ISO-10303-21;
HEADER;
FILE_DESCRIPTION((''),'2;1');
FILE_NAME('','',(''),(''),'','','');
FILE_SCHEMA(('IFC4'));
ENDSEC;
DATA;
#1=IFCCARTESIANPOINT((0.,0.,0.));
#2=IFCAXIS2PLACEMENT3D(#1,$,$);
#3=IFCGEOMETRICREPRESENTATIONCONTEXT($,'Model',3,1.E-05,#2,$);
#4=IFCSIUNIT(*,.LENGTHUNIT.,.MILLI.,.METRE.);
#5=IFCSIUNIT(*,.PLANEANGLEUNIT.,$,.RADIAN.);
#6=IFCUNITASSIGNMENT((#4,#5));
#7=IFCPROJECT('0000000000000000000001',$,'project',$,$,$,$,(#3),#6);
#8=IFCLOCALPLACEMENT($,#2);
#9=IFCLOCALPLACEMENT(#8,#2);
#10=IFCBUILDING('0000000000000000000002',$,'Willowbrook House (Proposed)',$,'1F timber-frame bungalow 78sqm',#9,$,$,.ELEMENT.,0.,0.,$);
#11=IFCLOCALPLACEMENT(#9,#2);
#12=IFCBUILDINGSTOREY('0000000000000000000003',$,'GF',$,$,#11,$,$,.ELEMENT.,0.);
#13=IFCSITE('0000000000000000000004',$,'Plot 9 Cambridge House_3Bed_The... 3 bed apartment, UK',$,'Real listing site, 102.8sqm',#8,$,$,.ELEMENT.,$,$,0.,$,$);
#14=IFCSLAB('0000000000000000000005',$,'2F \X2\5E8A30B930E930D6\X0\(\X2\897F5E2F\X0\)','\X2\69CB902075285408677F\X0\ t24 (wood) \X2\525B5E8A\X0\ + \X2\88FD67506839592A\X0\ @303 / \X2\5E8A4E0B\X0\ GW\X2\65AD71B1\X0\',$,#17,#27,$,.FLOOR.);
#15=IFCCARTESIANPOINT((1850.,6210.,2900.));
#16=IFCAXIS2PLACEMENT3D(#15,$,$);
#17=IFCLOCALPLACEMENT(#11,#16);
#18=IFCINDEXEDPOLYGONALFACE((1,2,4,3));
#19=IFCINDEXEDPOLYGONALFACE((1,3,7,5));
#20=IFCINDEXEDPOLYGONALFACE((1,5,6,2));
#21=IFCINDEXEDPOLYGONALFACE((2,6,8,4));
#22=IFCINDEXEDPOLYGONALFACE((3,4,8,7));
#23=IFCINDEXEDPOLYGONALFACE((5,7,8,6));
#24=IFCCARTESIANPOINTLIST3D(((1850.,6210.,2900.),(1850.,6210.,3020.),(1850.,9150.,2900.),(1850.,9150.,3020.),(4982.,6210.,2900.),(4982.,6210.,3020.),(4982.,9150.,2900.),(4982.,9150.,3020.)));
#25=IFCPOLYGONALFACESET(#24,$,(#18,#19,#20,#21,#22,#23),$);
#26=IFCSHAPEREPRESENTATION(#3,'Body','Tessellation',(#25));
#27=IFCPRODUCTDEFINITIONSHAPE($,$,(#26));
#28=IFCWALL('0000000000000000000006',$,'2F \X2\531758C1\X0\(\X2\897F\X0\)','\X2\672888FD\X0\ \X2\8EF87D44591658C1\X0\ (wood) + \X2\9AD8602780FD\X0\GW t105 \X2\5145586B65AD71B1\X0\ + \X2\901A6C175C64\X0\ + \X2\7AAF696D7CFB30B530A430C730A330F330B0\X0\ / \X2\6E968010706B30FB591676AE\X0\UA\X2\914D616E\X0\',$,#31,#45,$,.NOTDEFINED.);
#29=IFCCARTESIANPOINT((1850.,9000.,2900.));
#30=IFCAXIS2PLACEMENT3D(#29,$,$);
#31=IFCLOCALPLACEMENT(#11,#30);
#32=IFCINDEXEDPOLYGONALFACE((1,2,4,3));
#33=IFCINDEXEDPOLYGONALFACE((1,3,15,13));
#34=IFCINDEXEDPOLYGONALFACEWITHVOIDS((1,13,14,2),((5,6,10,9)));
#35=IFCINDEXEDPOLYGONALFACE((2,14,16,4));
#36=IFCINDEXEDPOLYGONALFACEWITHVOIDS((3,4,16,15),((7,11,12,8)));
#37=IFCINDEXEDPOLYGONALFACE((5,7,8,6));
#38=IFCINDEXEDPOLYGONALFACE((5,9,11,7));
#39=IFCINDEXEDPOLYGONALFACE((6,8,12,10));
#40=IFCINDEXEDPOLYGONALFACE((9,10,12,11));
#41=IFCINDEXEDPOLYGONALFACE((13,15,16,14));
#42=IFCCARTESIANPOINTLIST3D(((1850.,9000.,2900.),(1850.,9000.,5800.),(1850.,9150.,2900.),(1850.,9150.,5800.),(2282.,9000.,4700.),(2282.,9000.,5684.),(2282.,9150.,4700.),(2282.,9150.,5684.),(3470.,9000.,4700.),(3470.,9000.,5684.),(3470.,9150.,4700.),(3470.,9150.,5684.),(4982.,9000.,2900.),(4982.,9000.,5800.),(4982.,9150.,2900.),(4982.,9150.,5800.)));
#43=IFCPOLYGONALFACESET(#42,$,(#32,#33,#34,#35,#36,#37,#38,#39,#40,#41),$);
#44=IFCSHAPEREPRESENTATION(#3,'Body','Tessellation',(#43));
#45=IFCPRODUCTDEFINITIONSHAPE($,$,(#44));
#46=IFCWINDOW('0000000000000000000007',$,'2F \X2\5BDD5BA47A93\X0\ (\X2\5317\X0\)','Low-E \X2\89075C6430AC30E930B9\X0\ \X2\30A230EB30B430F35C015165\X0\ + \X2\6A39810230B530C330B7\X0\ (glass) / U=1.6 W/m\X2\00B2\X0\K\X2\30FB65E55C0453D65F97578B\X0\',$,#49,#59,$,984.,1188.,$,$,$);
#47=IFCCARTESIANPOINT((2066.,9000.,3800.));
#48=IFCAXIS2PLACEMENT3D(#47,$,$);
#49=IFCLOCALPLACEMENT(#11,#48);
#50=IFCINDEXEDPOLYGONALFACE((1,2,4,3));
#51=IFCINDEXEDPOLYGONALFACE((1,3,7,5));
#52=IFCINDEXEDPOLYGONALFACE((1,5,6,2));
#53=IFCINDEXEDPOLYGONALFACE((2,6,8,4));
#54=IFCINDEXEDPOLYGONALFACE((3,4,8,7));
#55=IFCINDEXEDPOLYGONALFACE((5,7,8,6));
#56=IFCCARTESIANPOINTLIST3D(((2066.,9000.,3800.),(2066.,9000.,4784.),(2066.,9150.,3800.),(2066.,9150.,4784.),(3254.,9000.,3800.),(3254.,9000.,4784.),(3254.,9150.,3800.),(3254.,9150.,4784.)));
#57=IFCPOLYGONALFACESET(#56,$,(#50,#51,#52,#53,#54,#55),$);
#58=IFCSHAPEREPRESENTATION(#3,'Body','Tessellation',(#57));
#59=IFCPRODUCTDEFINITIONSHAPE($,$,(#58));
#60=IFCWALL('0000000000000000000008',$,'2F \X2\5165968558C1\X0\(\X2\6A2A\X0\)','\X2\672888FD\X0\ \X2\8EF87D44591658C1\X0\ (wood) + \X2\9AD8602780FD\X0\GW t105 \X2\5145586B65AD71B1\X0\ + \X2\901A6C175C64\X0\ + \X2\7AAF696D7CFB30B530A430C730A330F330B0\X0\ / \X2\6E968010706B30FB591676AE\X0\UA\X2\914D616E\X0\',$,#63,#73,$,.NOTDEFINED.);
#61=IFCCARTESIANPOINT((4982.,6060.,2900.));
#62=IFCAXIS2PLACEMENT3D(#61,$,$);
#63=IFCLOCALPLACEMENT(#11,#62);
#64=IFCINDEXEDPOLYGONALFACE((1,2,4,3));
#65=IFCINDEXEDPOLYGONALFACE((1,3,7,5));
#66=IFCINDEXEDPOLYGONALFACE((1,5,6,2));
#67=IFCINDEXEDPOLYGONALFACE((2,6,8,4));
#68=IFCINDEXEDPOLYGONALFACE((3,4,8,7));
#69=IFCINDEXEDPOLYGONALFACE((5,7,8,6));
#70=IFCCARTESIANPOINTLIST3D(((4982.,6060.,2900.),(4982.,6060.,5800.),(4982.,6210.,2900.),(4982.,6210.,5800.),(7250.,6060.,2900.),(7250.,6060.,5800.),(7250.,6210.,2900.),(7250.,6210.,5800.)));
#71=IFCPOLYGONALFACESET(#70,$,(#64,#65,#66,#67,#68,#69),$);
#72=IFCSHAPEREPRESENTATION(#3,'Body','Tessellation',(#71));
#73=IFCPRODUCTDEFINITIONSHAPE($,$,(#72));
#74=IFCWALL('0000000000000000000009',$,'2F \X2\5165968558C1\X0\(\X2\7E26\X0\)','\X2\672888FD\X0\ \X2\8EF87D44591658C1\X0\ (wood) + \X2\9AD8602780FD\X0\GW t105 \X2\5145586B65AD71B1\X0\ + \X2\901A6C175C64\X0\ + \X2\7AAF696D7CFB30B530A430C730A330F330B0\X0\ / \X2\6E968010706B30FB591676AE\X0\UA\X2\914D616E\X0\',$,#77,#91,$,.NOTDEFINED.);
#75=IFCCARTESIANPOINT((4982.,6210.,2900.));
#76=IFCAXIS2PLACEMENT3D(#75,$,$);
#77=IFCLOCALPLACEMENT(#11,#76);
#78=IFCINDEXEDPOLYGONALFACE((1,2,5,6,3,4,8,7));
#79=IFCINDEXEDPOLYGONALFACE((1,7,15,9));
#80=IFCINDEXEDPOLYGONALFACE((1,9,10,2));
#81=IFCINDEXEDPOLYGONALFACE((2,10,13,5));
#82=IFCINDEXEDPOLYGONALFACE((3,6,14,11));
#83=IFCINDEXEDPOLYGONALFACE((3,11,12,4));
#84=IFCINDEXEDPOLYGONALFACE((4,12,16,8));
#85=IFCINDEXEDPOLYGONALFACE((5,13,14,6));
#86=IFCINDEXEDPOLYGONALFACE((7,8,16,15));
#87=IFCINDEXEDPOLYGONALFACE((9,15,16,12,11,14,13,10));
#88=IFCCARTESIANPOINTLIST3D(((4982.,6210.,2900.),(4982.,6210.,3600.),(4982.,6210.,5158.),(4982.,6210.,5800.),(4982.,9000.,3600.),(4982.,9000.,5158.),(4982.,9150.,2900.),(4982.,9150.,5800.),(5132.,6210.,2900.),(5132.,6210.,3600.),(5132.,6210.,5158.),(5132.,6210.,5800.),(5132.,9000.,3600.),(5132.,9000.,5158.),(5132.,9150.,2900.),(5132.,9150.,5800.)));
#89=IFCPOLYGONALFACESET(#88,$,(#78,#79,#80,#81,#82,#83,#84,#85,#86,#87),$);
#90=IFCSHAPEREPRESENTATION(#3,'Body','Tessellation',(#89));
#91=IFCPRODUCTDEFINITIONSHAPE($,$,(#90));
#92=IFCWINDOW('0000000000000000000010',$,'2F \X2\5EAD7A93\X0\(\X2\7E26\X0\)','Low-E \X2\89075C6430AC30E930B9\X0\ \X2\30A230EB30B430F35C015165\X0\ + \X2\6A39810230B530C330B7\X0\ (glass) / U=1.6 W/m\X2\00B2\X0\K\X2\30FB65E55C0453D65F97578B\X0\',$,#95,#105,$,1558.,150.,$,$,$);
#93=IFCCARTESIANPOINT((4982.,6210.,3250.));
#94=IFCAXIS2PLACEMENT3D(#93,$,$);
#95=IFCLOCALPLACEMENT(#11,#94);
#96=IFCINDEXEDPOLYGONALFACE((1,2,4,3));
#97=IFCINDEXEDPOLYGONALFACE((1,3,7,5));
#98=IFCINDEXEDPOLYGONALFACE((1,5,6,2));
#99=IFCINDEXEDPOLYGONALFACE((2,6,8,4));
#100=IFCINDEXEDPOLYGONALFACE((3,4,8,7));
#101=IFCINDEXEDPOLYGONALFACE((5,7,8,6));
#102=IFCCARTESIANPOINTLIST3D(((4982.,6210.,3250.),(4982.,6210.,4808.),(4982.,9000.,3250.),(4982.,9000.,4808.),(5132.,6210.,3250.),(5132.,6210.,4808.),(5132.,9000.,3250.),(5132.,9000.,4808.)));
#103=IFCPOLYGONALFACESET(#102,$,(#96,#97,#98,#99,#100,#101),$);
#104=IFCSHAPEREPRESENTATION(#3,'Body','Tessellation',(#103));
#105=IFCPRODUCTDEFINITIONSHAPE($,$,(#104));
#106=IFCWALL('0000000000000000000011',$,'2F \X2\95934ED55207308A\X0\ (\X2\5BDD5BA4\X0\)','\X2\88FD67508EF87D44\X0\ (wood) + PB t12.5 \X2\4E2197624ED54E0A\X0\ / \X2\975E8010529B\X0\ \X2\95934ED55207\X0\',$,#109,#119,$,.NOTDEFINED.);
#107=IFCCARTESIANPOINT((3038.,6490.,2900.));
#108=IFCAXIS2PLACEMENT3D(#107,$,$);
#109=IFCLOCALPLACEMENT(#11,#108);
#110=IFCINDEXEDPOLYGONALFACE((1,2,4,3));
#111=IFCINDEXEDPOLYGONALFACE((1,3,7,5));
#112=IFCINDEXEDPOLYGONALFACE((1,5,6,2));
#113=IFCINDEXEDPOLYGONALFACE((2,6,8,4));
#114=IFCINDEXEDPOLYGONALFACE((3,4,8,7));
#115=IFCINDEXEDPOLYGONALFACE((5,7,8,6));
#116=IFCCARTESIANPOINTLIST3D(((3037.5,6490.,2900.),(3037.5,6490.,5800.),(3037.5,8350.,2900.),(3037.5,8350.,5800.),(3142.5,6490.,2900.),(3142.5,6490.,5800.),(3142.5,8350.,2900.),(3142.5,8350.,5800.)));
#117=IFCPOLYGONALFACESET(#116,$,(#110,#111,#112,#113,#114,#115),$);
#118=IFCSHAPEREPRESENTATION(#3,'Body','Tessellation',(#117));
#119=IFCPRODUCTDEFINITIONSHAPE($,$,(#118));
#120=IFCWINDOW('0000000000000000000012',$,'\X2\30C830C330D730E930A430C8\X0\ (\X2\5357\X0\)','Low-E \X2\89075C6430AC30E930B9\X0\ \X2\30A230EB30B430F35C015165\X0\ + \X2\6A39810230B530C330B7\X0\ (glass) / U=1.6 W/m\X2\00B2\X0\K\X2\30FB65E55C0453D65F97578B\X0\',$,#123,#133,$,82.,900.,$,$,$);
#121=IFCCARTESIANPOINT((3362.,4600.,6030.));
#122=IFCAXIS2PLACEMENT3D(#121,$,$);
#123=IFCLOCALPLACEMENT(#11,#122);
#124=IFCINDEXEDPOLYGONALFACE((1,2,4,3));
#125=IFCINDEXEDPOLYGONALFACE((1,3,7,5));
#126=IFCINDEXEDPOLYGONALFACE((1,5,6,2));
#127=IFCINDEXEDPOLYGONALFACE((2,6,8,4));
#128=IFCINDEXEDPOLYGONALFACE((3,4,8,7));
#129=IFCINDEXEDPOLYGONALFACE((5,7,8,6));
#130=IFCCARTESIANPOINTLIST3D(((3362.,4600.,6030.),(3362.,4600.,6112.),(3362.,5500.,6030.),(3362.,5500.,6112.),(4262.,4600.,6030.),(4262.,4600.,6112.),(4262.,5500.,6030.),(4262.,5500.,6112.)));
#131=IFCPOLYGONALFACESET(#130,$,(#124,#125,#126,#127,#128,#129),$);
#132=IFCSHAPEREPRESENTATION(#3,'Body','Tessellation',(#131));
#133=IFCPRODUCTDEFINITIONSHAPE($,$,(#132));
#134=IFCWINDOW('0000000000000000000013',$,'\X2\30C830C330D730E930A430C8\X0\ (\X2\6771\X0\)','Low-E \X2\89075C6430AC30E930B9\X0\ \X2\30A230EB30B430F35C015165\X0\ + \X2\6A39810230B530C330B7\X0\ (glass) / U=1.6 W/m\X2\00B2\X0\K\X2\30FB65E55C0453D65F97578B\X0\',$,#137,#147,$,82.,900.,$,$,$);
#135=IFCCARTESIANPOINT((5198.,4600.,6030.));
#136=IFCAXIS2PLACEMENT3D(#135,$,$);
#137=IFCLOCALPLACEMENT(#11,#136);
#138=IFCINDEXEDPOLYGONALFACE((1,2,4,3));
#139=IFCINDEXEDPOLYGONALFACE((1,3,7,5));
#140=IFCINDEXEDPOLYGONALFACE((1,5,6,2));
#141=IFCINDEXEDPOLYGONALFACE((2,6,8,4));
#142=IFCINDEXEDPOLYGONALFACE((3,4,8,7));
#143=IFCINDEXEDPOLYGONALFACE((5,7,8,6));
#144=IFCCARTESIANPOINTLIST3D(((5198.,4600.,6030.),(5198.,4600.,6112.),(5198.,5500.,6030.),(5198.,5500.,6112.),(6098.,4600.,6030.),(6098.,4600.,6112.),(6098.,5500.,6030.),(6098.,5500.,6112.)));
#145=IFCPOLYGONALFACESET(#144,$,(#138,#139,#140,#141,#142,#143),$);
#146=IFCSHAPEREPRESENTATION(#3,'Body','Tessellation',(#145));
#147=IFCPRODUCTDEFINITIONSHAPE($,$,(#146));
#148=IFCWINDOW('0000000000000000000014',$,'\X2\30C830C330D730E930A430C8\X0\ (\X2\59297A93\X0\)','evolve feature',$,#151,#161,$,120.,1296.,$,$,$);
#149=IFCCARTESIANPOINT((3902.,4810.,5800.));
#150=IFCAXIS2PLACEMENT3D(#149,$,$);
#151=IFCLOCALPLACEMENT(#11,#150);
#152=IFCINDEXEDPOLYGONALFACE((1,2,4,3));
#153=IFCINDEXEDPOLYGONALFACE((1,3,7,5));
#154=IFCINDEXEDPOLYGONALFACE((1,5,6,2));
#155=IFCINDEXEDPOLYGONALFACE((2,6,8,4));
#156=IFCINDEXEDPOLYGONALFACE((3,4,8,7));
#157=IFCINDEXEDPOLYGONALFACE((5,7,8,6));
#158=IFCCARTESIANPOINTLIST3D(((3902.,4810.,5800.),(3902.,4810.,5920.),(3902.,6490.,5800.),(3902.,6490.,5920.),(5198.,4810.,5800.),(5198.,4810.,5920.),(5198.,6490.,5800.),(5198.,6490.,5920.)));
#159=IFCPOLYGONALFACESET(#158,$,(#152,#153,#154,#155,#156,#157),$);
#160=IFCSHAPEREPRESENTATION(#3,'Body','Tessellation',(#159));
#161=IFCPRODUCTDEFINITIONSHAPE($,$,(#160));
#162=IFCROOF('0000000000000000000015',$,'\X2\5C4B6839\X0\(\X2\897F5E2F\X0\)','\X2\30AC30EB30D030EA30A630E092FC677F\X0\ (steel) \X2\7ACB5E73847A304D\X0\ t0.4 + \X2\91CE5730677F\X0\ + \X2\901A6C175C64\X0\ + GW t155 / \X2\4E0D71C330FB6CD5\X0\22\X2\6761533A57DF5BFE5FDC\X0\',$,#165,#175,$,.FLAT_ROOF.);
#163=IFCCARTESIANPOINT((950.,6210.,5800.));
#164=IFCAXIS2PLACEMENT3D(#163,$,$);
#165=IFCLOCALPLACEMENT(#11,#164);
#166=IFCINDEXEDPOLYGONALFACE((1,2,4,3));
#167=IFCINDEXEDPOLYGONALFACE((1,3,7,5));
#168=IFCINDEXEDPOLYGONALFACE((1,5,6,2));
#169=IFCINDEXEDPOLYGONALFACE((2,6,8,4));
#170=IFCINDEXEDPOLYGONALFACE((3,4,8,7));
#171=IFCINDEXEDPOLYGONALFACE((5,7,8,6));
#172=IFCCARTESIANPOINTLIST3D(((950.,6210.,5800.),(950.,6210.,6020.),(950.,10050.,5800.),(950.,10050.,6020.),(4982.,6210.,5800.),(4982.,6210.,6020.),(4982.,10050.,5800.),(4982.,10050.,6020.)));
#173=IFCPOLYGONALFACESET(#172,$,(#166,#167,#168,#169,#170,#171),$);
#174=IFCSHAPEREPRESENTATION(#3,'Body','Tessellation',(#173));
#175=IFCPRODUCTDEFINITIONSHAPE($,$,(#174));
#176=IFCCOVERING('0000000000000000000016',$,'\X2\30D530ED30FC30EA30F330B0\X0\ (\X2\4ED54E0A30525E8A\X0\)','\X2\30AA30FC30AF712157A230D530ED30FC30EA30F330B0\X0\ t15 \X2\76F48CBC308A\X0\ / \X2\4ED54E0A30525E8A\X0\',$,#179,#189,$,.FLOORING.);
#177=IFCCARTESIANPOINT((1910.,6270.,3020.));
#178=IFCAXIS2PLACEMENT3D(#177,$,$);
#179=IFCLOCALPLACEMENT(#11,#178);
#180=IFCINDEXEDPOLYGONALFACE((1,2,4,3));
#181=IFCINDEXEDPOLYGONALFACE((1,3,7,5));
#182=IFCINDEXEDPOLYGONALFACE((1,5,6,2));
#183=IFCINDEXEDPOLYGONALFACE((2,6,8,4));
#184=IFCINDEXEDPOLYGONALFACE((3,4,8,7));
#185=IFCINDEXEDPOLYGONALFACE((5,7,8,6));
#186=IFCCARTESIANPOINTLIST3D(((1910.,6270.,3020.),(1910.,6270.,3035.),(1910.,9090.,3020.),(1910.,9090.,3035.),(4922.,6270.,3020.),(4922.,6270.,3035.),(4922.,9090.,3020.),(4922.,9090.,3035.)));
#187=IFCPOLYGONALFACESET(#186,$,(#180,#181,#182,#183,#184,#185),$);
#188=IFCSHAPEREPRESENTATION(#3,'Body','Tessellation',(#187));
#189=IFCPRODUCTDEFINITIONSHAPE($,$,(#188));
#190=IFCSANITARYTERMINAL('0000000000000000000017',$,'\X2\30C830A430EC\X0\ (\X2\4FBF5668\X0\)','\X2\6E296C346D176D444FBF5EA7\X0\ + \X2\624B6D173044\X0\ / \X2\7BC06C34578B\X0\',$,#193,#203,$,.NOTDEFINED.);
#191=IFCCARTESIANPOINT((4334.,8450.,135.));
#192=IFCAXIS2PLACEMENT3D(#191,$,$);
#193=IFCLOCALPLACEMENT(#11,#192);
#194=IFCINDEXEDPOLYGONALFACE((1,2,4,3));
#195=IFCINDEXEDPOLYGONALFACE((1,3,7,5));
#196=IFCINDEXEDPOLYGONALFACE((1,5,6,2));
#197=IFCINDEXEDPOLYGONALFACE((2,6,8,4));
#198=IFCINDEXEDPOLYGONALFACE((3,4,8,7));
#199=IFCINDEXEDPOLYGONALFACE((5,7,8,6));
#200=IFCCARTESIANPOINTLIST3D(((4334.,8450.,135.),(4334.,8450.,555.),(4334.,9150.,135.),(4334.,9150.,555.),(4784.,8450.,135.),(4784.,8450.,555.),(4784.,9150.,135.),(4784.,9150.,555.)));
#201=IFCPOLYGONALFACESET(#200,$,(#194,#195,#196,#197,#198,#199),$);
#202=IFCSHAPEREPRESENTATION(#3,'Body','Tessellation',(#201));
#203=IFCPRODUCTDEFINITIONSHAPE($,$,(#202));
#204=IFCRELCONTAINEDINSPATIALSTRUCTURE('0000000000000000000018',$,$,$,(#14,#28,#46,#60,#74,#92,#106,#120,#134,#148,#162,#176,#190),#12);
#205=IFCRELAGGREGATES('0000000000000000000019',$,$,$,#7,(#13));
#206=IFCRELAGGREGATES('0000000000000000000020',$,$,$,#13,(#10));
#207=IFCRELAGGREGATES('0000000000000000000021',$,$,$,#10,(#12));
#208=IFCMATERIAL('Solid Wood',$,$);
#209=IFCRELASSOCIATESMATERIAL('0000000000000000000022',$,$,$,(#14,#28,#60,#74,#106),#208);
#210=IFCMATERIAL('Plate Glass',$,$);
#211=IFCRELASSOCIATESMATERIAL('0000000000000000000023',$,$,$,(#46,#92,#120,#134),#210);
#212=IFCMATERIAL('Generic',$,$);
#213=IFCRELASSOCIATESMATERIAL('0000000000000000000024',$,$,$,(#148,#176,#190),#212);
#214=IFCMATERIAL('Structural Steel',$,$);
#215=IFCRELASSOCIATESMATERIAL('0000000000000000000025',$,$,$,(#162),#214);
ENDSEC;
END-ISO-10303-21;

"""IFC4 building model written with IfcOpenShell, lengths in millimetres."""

from ifc_helpers import new_model, si_unit, frame, frame_2d, origin, place, context, project, spatial, rectangle, extrude, material, element, fill, save


model = new_model("IFC4")

# Units and contexts
model_context = context("Model", 3, precision=1e-05, world=origin())
ifc_project = project(units=[si_unit("LENGTHUNIT", "METRE", prefix="MILLI"), si_unit("PLANEANGLEUNIT", "RADIAN")], contexts=[model_context])

# Site, building, storey
site_placement = place(None, origin())
site = spatial("IfcSite", under=ifc_project, at=site_placement, Name="Plot 9 Cambridge House_3Bed_The... 3 bed apartment, UK", ObjectType="Real listing site, 102.8sqm", CompositionType="ELEMENT", RefElevation=0.0)
building_placement = place(site_placement, origin())
building = spatial("IfcBuilding", under=site, at=building_placement, Name="Willowbrook House (Proposed)", ObjectType="1F timber-frame bungalow 78sqm", CompositionType="ELEMENT", ElevationOfRefHeight=0.0, ElevationOfTerrain=0.0)
storey_placement = place(building_placement, origin())
storey = spatial("IfcBuildingStorey", under=building, at=storey_placement, Name="GF", CompositionType="ELEMENT", Elevation=0.0)

# Slab
ifc_material_1 = material(Name="Solid Wood")
slab_placement = place(storey_placement, frame((1850.0, 6210.0, 2900.0)))
element("IfcSlab", 1, at=slab_placement, inside=storey, material=ifc_material_1, Name="2F 床スラブ(西帯)", Description="構造用合板 t24 (wood) 剛床 + 製材根太 @303 / 床下 GW断熱", PredefinedType="FLOOR", context=model_context, shape_type="SweptSolid", body=[
    extrude(rectangle(XDim=3132.0, YDim=2940.0, at=frame_2d((1566.0, 1470.0))), frame((1850.0, 6210.0, 2900.0)), (0.0, 0.0, 1.0), 120.0),
])

# Wall, opening, window
wall_1_placement = place(storey_placement, frame((1850.0, 9000.0, 2900.0)))
wall_1 = element("IfcWall", 2, at=wall_1_placement, inside=storey, material=ifc_material_1, Name="2F 北壁(西)", Description="木製 軸組外壁 (wood) + 高性能GW t105 充填断熱 + 通気層 + 窯業系サイディング / 準耐火・外皮UA配慮", PredefinedType="NOTDEFINED", context=model_context, shape_type="SweptSolid", body=[
    extrude(rectangle(XDim=3132.0, YDim=150.0, at=frame_2d((1566.0, 75.0))), frame((1850.0, 9000.0, 2900.0)), (0.0, 0.0, 1.0), 2900.0),
])
opening_1_placement = place(storey_placement, frame((2066.0, 9000.0, 3800.0)))
opening_1 = element("IfcOpeningElement", 3, at=opening_1_placement, cuts=wall_1, PredefinedType="NOTDEFINED", context=model_context, shape_type="SweptSolid", body=[
    extrude(rectangle(XDim=1188.0, YDim=150.0, at=frame_2d((594.0, 75.0))), frame((2066.0, 9000.0, 3800.0)), (0.0, 0.0, 1.0), 984.0),
])
ifc_material_2 = material(Name="Plate Glass")
window_1_placement = place(storey_placement, frame((2066.0, 9000.0, 3800.0)))
window_1 = element("IfcWindow", 4, at=window_1_placement, inside=storey, material=ifc_material_2, Name="2F 寝室窓 (北)", Description="Low-E 複層ガラス アルゴン封入 + 樹脂サッシ (glass) / U=1.6 W/m²K・日射取得型", OverallHeight=984.0, OverallWidth=1188.0, context=model_context, shape_type="SweptSolid", body=[
    extrude(rectangle(XDim=1188.0, YDim=150.0, at=frame_2d((594.0, 75.0))), frame((2066.0, 9000.0, 3800.0)), (0.0, 0.0, 1.0), 984.0),
])
fill(opening_1, window_1)

# Wall
wall_2_placement = place(storey_placement, frame((4982.0, 6060.0, 2900.0)))
element("IfcWall", 5, at=wall_2_placement, inside=storey, material=ifc_material_1, Name="2F 入隅壁(横)", Description="木製 軸組外壁 (wood) + 高性能GW t105 充填断熱 + 通気層 + 窯業系サイディング / 準耐火・外皮UA配慮", PredefinedType="NOTDEFINED", context=model_context, shape_type="SweptSolid", body=[
    extrude(rectangle(XDim=2268.0, YDim=150.0, at=frame_2d((1134.0, 75.0))), frame((4982.0, 6060.0, 2900.0)), (0.0, 0.0, 1.0), 2900.0),
])

# Wall, opening, window
wall_3_placement = place(storey_placement, frame((4982.0, 6210.0, 2900.0)))
wall_3 = element("IfcWall", 6, at=wall_3_placement, inside=storey, material=ifc_material_1, Name="2F 入隅壁(縦)", Description="木製 軸組外壁 (wood) + 高性能GW t105 充填断熱 + 通気層 + 窯業系サイディング / 準耐火・外皮UA配慮", PredefinedType="NOTDEFINED", context=model_context, shape_type="SweptSolid", body=[
    extrude(rectangle(XDim=150.0, YDim=2940.0, at=frame_2d((75.0, 1470.0))), frame((4982.0, 6210.0, 2900.0)), (0.0, 0.0, 1.0), 2900.0),
])
opening_2_placement = place(storey_placement, frame((4982.0, 6210.0, 3250.0)))
opening_2 = element("IfcOpeningElement", 7, at=opening_2_placement, cuts=wall_3, PredefinedType="NOTDEFINED", context=model_context, shape_type="SweptSolid", body=[
    extrude(rectangle(XDim=150.0, YDim=2790.0, at=frame_2d((75.0, 1395.0))), frame((4982.0, 6210.0, 3250.0)), (0.0, 0.0, 1.0), 1558.0),
])
window_2_placement = place(storey_placement, frame((4982.0, 6210.0, 3250.0)))
window_2 = element("IfcWindow", 8, at=window_2_placement, inside=storey, material=ifc_material_2, Name="2F 庭窓(縦)", Description="Low-E 複層ガラス アルゴン封入 + 樹脂サッシ (glass) / U=1.6 W/m²K・日射取得型", OverallHeight=1558.0, OverallWidth=150.0, context=model_context, shape_type="SweptSolid", body=[
    extrude(rectangle(XDim=150.0, YDim=2790.0, at=frame_2d((75.0, 1395.0))), frame((4982.0, 6210.0, 3250.0)), (0.0, 0.0, 1.0), 1558.0),
])
fill(opening_2, window_2)

# Wall
wall_4_placement = place(storey_placement, frame((3038.0, 6490.0, 2900.0)))
element("IfcWall", 9, at=wall_4_placement, inside=storey, material=ifc_material_1, Name="2F 間仕切り (寝室)", Description="製材軸組 (wood) + PB t12.5 両面仕上 / 非耐力 間仕切", PredefinedType="NOTDEFINED", context=model_context, shape_type="SweptSolid", body=[
    extrude(rectangle(XDim=105.0, YDim=1860.0, at=frame_2d((52.0, 930.0))), frame((3038.0, 6490.0, 2900.0)), (0.0, 0.0, 1.0), 2900.0),
])

# Windows
window_3_placement = place(storey_placement, frame((3362.0, 4600.0, 6030.0)))
element("IfcWindow", 10, at=window_3_placement, inside=storey, material=ifc_material_2, Name="トップライト (南)", Description="Low-E 複層ガラス アルゴン封入 + 樹脂サッシ (glass) / U=1.6 W/m²K・日射取得型", OverallHeight=82.0, OverallWidth=900.0, context=model_context, shape_type="SweptSolid", body=[
    extrude(rectangle(XDim=900.0, YDim=900.0, at=frame_2d((450.0, 450.0))), frame((3362.0, 4600.0, 6030.0)), (0.0, 0.0, 1.0), 82.0),
])
window_4_placement = place(storey_placement, frame((5198.0, 4600.0, 6030.0)))
element("IfcWindow", 11, at=window_4_placement, inside=storey, material=ifc_material_2, Name="トップライト (東)", Description="Low-E 複層ガラス アルゴン封入 + 樹脂サッシ (glass) / U=1.6 W/m²K・日射取得型", OverallHeight=82.0, OverallWidth=900.0, context=model_context, shape_type="SweptSolid", body=[
    extrude(rectangle(XDim=900.0, YDim=900.0, at=frame_2d((450.0, 450.0))), frame((5198.0, 4600.0, 6030.0)), (0.0, 0.0, 1.0), 82.0),
])
ifc_material_3 = material(Name="Generic")
window_5_placement = place(storey_placement, frame((3902.0, 4810.0, 5800.0)))
element("IfcWindow", 12, at=window_5_placement, inside=storey, material=ifc_material_3, Name="トップライト (天窓)", Description="evolve feature", OverallHeight=120.0, OverallWidth=1296.0, context=model_context, shape_type="SweptSolid", body=[
    extrude(rectangle(XDim=1296.0, YDim=1680.0, at=frame_2d((648.0, 840.0))), frame((3902.0, 4810.0, 5800.0)), (0.0, 0.0, 1.0), 120.0),
])

# Roof
ifc_material_4 = material(Name="Structural Steel")
for number, where, name in (
    (13, (950.0, 6210.0, 5800.0), "屋根(西帯)"),
):
    element("IfcRoof", number, at=place(storey_placement, frame(where)), inside=storey, material=ifc_material_4, Name=name, Description="ガルバリウム鋼板 (steel) 立平葺き t0.4 + 野地板 + 通気層 + GW t155 / 不燃・法22条区域対応", PredefinedType="FLAT_ROOF", context=model_context, shape_type="SweptSolid", body=[
        extrude(rectangle(XDim=4032.0, YDim=3840.0, at=frame_2d((2016.0, 1920.0))), frame((950.0, 6210.0, 5800.0)), (0.0, 0.0, 1.0), 220.0),
    ])

# Covering
covering_placement = place(storey_placement, frame((1910.0, 6270.0, 3020.0)))
element("IfcCovering", 14, at=covering_placement, inside=storey, material=ifc_material_3, Name="フローリング (仕上げ床)", Description="オーク無垢フローリング t15 直貼り / 仕上げ床", PredefinedType="FLOORING", context=model_context, shape_type="SweptSolid", body=[
    extrude(rectangle(XDim=3012.0, YDim=2820.0, at=frame_2d((1506.0, 1410.0))), frame((1910.0, 6270.0, 3020.0)), (0.0, 0.0, 1.0), 15.0),
])

# Sanitary terminal
sanitary_terminal_placement = place(storey_placement, frame((4334.0, 8450.0, 135.0)))
element("IfcSanitaryTerminal", 15, at=sanitary_terminal_placement, inside=storey, material=ifc_material_3, Name="トイレ (便器)", Description="温水洗浄便座 + 手洗い / 節水型", PredefinedType="NOTDEFINED", context=model_context, shape_type="SweptSolid", body=[
    extrude(rectangle(XDim=450.0, YDim=700.0, at=frame_2d((225.0, 350.0))), frame((4334.0, 8450.0, 135.0)), (0.0, 0.0, 1.0), 420.0),
])

save(model, "model.ifc")
